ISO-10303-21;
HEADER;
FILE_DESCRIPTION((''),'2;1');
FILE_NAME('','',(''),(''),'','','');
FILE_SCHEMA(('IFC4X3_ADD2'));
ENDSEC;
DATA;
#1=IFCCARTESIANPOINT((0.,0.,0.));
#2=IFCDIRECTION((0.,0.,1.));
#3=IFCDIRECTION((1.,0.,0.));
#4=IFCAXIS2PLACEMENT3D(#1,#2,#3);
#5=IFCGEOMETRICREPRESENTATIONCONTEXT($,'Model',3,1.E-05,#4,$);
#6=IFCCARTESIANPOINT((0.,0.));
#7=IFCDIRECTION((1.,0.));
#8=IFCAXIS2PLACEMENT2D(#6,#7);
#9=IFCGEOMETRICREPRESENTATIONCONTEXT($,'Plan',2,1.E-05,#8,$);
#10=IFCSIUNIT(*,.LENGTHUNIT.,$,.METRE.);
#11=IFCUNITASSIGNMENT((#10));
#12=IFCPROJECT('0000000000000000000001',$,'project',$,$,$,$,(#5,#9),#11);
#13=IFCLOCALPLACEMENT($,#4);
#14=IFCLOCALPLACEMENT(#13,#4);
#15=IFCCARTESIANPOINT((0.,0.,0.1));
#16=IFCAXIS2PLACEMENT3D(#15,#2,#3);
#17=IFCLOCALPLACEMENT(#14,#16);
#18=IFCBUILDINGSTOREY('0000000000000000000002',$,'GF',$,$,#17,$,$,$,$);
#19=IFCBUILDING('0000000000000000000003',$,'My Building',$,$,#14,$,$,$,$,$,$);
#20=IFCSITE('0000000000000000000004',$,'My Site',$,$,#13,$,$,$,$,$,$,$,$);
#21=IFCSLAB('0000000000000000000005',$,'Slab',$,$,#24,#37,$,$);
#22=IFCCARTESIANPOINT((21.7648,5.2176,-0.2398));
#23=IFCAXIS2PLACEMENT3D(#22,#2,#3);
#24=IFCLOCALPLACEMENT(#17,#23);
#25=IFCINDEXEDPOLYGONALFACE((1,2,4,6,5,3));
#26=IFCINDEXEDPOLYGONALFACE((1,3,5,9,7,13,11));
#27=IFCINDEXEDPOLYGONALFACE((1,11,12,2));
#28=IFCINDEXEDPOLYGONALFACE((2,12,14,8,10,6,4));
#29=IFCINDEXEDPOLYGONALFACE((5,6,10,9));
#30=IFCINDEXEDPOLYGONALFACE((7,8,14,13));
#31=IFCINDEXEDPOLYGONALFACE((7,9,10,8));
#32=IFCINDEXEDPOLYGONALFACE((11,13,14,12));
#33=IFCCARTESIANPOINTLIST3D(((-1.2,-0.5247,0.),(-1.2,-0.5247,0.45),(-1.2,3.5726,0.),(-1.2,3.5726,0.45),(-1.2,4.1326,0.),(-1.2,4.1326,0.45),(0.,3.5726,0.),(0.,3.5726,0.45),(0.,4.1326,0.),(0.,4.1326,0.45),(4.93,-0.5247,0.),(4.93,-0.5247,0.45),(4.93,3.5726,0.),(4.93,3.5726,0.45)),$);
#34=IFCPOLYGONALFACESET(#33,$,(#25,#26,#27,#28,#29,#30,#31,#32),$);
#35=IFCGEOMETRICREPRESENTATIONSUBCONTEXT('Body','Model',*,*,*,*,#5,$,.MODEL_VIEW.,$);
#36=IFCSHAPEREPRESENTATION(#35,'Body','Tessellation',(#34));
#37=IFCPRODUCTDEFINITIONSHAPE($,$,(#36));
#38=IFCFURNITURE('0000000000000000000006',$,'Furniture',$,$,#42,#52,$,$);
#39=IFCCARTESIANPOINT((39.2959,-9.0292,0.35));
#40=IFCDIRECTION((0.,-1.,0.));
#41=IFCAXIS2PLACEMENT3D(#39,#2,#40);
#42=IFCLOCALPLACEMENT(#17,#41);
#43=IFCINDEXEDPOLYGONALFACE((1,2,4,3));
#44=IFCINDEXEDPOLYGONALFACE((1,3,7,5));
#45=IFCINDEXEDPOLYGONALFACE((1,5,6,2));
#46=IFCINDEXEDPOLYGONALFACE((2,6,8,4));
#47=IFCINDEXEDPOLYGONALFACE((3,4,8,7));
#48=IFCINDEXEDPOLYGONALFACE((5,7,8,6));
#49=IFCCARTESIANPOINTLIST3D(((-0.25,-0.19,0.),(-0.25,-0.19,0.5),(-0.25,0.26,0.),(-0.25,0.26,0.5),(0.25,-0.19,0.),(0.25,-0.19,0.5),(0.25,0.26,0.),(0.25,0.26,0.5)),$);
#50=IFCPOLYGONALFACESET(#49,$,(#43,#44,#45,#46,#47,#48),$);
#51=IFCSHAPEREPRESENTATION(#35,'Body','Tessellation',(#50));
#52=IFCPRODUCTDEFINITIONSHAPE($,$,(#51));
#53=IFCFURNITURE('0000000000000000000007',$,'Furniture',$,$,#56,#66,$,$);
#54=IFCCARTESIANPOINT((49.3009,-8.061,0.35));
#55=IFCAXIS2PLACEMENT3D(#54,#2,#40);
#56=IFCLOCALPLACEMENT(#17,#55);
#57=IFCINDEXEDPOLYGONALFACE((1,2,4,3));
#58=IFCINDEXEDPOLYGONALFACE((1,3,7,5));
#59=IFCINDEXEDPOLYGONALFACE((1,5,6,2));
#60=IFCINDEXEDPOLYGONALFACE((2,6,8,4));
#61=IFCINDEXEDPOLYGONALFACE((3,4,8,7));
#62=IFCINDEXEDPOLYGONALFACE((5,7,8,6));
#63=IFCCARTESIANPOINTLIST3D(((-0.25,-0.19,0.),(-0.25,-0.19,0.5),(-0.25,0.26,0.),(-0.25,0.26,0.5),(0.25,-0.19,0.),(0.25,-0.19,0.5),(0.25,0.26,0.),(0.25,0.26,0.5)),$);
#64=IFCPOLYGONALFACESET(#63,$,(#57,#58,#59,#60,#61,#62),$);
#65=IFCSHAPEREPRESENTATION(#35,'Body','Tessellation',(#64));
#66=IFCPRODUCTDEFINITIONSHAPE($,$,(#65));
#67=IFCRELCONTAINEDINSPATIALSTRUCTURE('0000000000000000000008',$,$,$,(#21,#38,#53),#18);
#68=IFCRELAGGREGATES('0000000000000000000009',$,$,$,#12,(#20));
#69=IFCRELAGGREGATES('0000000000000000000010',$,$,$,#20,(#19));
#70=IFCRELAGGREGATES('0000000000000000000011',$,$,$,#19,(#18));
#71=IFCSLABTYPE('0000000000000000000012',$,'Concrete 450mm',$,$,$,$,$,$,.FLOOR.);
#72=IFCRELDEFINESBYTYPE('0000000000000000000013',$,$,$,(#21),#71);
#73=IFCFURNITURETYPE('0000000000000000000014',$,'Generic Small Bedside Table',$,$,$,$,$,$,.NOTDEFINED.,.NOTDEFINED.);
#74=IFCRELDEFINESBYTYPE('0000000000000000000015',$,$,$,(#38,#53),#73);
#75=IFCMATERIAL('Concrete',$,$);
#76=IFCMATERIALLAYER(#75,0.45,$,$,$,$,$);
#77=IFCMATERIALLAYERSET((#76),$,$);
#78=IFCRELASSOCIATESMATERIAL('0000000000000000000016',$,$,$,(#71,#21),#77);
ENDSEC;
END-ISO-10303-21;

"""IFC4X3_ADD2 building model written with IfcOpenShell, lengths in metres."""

from ifc_helpers import new_model, entity, si_unit, frame, origin_with_axes, origin_2d_with_axis, place, context, subcontext, project, spatial, line, indexed_curve, outline, extrude, shape, source, transform, mapped, material, layer, layer_set, layer_usage, type_object, type_shapes, element, save


model = new_model("IFC4X3_ADD2")

# Units and contexts
model_context = context("Model", 3, precision=1e-05, world=origin_with_axes())
plan_context = context("Plan", 2, precision=1e-05, world=origin_2d_with_axis())
body_context_1 = subcontext(model_context, "Body", "Model", "MODEL_VIEW")
body_context_2 = subcontext(plan_context, "Body", "Plan", "PLAN_VIEW")
ifc_project = project(units=[si_unit("LENGTHUNIT", "METRE")], contexts=[model_context, plan_context])

# Site, building, storey
site_placement = place(None, origin_with_axes())
site = spatial("IfcSite", under=ifc_project, at=site_placement, Name="My Site")
building_placement = place(site_placement, origin_with_axes())
building = spatial("IfcBuilding", under=site, at=building_placement, Name="My Building")
storey_placement = place(building_placement, frame((0.0, 0.0, 0.1), z_axis=(0.0, 0.0, 1.0), x_axis=(1.0, 0.0, 0.0)))
storey = spatial("IfcBuildingStorey", under=building, at=storey_placement, Name="GF")

# Slab
ifc_material_1 = material(Name="Concrete")
ifc_layer = layer(ifc_material_1, 0.45)
ifc_layer_set = layer_set([ifc_layer])
ifc_layer_usage = layer_usage(ifc_layer_set, "AXIS3", "POSITIVE", 0.0)
slab_type = type_object("IfcSlabType", Name="Concrete 450mm", PredefinedType="FLOOR", material=ifc_layer_set)
slab_placement = place(storey_placement, frame((21.7648, 5.2176, -0.2398), z_axis=(0.0, 0.0, 1.0), x_axis=(1.0, 0.0, 0.0)))
element("IfcSlab", 1, at=slab_placement, inside=storey, type_object=slab_type, material=ifc_layer_usage, Name="Slab", context=body_context_1, shape_type="SweptSolid", body=[
    extrude(outline(indexed_curve([(4.93, -0.5247), (-1.2, -0.5247), (-1.2, 3.5726), (-1.2, 4.1326), (0.0, 4.1326), (0.0, 3.5726), (4.93, 3.5726)], segments=[line(3, 2), line(2, 1), line(1, 7), line(7, 6), line(6, 5), line(5, 4), line(4, 3)], self_intersect=False)), None, (0.0, 0.0, 1.0), 0.45),
])

# Furniture
furniture_type_1 = type_object("IfcFurnitureType", Name="Generic Small Bedside Table", AssemblyPlace="NOTDEFINED", PredefinedType="NOTDEFINED")
shared_shape_1 = source(origin_with_axes(), body_context_1, "Body", "SweptSolid", [
    extrude(outline(indexed_curve([(0.5, 0.45), (0.5, 0.0), (0.0, 0.0), (0.0, 0.45)], segments=[line(4, 1), line(1, 2), line(2, 3), line(3, 4)], self_intersect=False)), frame((-0.25, -0.19, 0.0), z_axis=(0.0, 0.0, 1.0), x_axis=(1.0, 0.0, 0.0)), (0.0, 0.0, 1.0), 0.5),
])
shared_shape_2 = source(origin_with_axes(), body_context_2, "Body", "Annotation2D", [
    entity("IfcGeometricCurveSet", [entity("IfcIndexedPolyCurve", entity("IfcCartesianPointList2D", [[-0.25, -0.19], [0.25, -0.19], [0.25, 0.26], [-0.25, 0.26]]), [entity("IfcLineIndex", [1, 2]), entity("IfcLineIndex", [2, 3]), entity("IfcLineIndex", [3, 4]), entity("IfcLineIndex", [4, 1])])]),
])
type_shapes(furniture_type_1, [shared_shape_1, shared_shape_2])
for number, where, z_axis, x_axis, name in (
    (2, (39.2959, -9.0292, 0.35), (0.0, 0.0, 1.0), (0.0, -1.0, 0.0), "Furniture"),
    (3, (49.3009, -8.061, 0.35), (0.0, 0.0, 1.0), (0.0, -1.0, 0.0), "Furniture"),
):
    element("IfcFurniture", number, at=place(storey_placement, frame(where, z_axis=z_axis, x_axis=x_axis)), inside=storey, type_object=furniture_type_1, Name=name, shapes=[
        shape(body_context_1, "Body", "MappedRepresentation", [mapped(shared_shape_1, transform((0.0, 0.0, 0.0), x_axis=(1.0, 0.0, 0.0), y_axis=(0.0, 1.0, 0.0), z_axis=(0.0, 0.0, 1.0), scale=1.0))]),
        shape(body_context_2, "Body", "MappedRepresentation", [mapped(shared_shape_2, transform((0.0, 0.0, 0.0), x_axis=(1.0, 0.0, 0.0), y_axis=(0.0, 1.0, 0.0), z_axis=(0.0, 0.0, 1.0), scale=1.0))]),
    ])

save(model, "model.ifc")
